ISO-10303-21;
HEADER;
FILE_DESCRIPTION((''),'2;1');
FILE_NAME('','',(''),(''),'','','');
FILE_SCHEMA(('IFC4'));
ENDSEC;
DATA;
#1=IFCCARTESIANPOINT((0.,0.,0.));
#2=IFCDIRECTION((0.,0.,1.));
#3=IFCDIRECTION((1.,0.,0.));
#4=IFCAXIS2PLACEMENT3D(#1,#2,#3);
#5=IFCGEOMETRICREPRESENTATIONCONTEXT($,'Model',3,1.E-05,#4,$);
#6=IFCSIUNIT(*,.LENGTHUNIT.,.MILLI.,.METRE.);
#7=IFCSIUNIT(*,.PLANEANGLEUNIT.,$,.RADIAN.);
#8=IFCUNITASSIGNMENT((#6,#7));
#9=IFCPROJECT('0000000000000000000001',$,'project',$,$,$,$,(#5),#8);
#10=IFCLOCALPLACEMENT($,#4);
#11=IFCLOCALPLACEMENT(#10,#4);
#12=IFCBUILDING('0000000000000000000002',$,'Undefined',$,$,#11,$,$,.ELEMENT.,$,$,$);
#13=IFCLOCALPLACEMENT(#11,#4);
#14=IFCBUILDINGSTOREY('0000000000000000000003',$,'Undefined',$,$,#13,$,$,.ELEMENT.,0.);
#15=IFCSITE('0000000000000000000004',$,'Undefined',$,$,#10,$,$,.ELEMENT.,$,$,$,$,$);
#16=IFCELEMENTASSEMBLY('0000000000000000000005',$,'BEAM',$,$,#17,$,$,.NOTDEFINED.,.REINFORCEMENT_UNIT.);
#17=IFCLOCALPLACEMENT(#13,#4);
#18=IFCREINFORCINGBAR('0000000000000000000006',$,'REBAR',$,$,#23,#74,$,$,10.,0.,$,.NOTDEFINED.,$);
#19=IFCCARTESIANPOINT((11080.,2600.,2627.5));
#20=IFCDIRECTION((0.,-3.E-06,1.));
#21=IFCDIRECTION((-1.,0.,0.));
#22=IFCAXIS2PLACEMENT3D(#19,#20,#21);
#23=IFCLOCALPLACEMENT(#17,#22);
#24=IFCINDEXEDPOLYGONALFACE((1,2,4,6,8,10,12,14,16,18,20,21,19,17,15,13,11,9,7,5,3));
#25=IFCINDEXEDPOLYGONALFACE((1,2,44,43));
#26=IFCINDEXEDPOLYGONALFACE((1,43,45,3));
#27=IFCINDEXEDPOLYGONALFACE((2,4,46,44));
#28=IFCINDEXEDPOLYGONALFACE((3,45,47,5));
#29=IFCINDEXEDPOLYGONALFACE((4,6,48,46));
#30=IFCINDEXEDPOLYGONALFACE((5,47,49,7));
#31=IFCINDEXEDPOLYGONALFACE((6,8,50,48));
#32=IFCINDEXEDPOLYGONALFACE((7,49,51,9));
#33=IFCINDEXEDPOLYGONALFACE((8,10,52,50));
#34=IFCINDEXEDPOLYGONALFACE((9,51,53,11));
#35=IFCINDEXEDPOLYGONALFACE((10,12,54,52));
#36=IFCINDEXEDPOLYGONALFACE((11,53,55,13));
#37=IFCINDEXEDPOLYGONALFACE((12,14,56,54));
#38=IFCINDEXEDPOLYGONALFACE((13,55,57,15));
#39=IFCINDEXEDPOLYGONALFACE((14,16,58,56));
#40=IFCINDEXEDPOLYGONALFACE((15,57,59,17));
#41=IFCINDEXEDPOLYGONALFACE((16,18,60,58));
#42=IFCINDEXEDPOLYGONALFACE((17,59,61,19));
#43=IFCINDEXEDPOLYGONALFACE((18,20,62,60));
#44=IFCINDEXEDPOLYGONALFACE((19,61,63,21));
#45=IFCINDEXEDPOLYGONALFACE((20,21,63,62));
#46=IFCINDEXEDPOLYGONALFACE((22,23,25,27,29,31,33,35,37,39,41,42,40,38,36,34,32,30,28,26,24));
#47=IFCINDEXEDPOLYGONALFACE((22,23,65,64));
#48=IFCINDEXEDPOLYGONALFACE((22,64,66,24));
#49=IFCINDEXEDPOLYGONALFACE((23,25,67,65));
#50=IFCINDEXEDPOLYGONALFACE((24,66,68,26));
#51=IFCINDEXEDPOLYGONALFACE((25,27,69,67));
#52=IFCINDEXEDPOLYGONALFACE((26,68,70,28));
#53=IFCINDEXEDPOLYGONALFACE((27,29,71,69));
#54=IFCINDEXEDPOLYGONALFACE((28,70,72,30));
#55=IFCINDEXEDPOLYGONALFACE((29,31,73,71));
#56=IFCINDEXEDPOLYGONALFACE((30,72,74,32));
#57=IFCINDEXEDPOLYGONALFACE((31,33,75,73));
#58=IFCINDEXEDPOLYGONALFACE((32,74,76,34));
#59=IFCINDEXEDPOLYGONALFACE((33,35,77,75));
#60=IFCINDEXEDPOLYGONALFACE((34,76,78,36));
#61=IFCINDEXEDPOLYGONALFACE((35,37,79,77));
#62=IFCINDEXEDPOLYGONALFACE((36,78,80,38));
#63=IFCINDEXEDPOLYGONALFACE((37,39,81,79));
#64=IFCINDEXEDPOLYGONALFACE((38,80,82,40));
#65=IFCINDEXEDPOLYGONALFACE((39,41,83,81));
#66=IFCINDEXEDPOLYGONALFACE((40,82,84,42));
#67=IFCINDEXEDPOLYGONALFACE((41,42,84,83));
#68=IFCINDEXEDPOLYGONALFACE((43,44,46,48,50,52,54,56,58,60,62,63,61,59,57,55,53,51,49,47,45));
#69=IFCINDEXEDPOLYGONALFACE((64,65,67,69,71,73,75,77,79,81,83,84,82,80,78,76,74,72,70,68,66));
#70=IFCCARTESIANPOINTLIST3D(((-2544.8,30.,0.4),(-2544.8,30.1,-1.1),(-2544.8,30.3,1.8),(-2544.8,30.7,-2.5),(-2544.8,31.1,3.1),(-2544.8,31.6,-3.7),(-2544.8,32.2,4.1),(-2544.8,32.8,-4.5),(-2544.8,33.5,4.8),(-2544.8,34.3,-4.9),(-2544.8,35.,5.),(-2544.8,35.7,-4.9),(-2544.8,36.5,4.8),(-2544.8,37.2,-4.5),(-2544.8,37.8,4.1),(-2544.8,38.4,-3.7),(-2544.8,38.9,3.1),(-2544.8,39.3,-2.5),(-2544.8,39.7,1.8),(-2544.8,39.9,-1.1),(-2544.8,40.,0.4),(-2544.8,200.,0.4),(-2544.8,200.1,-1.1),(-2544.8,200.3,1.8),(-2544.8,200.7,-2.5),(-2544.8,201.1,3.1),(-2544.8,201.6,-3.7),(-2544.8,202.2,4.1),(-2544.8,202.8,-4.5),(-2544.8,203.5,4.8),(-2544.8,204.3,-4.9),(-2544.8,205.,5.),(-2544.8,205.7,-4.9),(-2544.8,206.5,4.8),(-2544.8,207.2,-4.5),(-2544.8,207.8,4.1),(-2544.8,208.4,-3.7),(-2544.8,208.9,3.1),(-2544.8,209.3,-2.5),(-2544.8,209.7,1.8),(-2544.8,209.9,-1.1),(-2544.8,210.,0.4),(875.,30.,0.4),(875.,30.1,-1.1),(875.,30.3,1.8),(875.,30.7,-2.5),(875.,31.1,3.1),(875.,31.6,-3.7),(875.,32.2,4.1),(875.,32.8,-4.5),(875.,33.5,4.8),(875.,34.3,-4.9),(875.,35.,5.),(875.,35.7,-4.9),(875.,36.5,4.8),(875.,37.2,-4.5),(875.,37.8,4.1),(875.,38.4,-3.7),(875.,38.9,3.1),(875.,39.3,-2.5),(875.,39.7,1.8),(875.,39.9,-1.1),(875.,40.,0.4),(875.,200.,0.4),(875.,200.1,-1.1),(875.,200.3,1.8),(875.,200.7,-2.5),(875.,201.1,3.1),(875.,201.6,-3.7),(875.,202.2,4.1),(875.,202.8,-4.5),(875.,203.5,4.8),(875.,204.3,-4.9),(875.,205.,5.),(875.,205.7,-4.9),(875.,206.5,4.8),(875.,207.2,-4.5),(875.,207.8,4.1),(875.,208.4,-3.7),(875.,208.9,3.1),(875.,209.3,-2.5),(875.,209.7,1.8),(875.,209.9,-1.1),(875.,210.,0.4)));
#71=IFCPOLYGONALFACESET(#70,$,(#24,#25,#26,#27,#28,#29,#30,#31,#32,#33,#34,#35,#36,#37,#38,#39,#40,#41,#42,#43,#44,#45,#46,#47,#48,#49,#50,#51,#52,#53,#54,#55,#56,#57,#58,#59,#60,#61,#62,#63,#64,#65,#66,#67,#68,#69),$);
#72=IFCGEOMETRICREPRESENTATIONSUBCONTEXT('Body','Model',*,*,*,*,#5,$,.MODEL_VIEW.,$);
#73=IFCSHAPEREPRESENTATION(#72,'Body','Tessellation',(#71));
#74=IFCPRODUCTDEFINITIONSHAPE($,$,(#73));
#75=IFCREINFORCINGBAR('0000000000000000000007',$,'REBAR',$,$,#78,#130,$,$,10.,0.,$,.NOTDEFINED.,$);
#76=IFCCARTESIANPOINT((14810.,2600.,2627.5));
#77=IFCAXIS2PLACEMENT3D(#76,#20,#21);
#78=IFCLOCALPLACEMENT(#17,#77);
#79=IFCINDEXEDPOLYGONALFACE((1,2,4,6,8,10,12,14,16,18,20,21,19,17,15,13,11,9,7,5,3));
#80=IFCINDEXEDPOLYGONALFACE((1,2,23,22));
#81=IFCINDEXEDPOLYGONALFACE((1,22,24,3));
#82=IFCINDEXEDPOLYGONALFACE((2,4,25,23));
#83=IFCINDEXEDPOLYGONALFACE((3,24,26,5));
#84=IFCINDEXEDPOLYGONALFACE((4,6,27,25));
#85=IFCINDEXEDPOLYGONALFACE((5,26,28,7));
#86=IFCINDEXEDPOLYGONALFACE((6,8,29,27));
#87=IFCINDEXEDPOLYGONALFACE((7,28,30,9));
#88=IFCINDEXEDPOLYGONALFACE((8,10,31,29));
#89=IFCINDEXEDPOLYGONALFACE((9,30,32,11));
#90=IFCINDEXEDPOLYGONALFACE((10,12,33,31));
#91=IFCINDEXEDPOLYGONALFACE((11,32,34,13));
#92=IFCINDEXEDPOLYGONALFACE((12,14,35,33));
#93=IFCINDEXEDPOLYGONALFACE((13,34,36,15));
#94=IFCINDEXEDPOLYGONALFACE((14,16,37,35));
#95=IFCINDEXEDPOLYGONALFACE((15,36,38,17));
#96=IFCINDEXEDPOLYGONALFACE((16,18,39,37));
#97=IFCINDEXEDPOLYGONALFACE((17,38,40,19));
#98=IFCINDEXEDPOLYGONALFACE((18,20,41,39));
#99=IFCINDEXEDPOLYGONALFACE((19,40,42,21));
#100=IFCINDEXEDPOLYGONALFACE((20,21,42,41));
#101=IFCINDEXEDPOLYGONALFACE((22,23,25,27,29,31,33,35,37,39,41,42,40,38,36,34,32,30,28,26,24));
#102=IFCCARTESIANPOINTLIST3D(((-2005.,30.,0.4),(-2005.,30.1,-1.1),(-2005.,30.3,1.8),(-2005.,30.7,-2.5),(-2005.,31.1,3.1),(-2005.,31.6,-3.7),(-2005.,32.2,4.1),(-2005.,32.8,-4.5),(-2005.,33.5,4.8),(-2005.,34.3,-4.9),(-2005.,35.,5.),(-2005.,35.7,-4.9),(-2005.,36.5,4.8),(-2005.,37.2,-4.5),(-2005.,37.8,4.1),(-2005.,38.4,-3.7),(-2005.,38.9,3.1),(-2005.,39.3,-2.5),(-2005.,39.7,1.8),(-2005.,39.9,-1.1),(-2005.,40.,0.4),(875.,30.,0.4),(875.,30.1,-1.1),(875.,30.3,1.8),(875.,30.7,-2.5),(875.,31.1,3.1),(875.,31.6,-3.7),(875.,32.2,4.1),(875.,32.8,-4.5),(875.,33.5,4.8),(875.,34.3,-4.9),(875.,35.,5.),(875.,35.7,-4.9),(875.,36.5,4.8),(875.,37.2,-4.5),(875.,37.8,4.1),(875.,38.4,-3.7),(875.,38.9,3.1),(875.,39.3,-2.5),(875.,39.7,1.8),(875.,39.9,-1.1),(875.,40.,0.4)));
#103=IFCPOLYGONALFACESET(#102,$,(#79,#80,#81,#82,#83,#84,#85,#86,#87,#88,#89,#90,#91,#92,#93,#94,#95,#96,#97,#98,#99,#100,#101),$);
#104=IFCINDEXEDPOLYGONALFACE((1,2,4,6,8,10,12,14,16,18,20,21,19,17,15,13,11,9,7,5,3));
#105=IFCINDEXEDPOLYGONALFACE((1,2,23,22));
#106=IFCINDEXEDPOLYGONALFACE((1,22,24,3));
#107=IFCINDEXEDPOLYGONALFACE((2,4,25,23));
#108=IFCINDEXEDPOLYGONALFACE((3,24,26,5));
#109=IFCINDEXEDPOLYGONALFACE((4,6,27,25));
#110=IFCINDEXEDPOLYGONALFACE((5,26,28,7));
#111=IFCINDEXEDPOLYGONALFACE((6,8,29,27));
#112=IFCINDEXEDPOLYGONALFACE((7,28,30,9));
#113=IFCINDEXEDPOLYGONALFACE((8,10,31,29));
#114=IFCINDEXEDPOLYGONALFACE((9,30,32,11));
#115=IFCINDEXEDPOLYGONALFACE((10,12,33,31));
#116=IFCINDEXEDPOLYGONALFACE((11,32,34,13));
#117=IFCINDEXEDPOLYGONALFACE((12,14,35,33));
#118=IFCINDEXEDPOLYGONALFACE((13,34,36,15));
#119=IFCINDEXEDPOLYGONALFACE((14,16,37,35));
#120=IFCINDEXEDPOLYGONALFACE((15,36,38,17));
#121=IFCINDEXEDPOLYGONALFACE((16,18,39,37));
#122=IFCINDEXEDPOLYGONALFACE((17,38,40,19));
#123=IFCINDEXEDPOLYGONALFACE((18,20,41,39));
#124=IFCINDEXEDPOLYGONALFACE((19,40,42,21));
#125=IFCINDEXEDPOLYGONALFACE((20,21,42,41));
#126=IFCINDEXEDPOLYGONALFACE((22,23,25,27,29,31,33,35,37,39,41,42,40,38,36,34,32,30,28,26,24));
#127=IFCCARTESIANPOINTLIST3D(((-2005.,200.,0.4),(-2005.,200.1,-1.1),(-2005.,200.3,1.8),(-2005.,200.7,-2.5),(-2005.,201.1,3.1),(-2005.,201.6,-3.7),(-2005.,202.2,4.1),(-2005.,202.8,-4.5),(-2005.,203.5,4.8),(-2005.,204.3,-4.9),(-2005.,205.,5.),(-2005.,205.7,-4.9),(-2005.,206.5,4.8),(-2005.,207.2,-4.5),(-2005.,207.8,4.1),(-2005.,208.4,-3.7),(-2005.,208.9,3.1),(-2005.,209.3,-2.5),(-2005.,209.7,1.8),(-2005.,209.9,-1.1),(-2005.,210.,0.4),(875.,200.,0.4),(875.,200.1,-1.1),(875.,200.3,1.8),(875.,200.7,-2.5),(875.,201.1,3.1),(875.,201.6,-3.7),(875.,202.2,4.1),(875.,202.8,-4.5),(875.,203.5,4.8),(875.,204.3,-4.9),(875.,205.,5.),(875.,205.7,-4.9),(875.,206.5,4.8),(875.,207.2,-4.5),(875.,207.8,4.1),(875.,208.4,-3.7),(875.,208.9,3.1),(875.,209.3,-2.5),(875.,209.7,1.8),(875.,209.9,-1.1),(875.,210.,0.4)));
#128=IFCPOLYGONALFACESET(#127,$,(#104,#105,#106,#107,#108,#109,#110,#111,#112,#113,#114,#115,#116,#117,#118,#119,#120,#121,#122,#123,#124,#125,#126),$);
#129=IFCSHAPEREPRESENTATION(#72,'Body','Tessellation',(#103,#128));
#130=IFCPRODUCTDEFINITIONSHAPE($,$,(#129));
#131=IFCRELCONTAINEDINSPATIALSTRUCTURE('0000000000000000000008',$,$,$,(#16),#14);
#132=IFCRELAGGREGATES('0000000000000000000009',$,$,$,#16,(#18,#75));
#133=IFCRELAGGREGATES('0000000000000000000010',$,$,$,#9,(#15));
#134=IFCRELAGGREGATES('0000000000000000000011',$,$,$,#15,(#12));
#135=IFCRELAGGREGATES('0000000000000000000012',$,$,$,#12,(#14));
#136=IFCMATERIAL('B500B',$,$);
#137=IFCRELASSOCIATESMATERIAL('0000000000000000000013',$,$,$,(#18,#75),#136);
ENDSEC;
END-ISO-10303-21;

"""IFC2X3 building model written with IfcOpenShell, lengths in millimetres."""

from ifc_helpers import new_model, entity, si_unit, frame, origin_with_axes, place, context, subcontext, project, spatial, source, transform, mapped, material, element, aggregate, save


model = new_model("IFC2X3")

# Units and contexts
model_context = context("Model", 3, precision=1e-05, world=origin_with_axes())
body_context = subcontext(model_context, "Body", "Model", "MODEL_VIEW")
ifc_project = project(units=[si_unit("LENGTHUNIT", "METRE", prefix="MILLI"), si_unit("PLANEANGLEUNIT", "RADIAN")], contexts=[model_context])

# Site, building, storey
site_placement = place(None, origin_with_axes())
site = spatial("IfcSite", under=ifc_project, at=site_placement, Name="Undefined", CompositionType="ELEMENT")
building_placement = place(site_placement, origin_with_axes())
building = spatial("IfcBuilding", under=site, at=building_placement, Name="Undefined", CompositionType="ELEMENT")
storey_placement = place(building_placement, origin_with_axes())
storey = spatial("IfcBuildingStorey", under=building, at=storey_placement, Name="Undefined", CompositionType="ELEMENT", Elevation=0.0)

# Element assembly
assembly_1_placement = place(storey_placement, origin_with_axes())
assembly_1 = element("IfcElementAssembly", 1, at=assembly_1_placement, inside=storey, Name="BEAM", AssemblyPlace="NOTDEFINED", PredefinedType="REINFORCEMENT_UNIT")

# Reinforcing bars
ifc_material_1 = material(Name="B500B")
shared_shape_1 = source(origin_with_axes(), body_context, "Body", "AdvancedSweptSolid", [
    entity("IfcSweptDiskSolid", entity("IfcTrimmedCurve", entity("IfcLine", entity("IfcCartesianPoint", [0.0, 0.0, 0.0]), entity("IfcVector", entity("IfcDirection", [1.0, 0.0, 0.0]), 1.0)), [entity("IfcParameterValue", 0.0)], [entity("IfcParameterValue", 3419.772834)], True, "PARAMETER"), 5.0, None, 0.0, 3419.8),
])
shared_shape_2 = source(origin_with_axes(), body_context, "Body", "AdvancedSweptSolid", [
    entity("IfcSweptDiskSolid", entity("IfcTrimmedCurve", entity("IfcLine", entity("IfcCartesianPoint", [0.0, 0.0, 0.0]), entity("IfcVector", entity("IfcDirection", [1.0, 0.0, 0.0]), 1.0)), [entity("IfcParameterValue", 0.0)], [entity("IfcParameterValue", 3419.772834)], True, "PARAMETER"), 5.0, None, 0.0, 3419.8),
])
reinforcing_bar_1_placement = place(assembly_1_placement, frame((11080.0, 2600.0, 2627.5), z_axis=(0.0, -0.000003, 1.0), x_axis=(-1.0, 0.0, 0.0)))
reinforcing_bar_1 = element("IfcReinforcingBar", 2, at=reinforcing_bar_1_placement, material=ifc_material_1, Name="REBAR", BarRole="NOTDEFINED", CrossSectionArea=0.0, NominalDiameter=10.0, context=body_context, shape_type="MappedRepresentation", body=[
    mapped(shared_shape_1, transform((-2544.8, 35.0, 0.0))),
    mapped(shared_shape_2, transform((-2544.8, 205.0, 0.0))),
])
shared_shape_3 = source(origin_with_axes(), body_context, "Body", "AdvancedSweptSolid", [
    entity("IfcSweptDiskSolid", entity("IfcTrimmedCurve", entity("IfcLine", entity("IfcCartesianPoint", [0.0, 0.0, 0.0]), entity("IfcVector", entity("IfcDirection", [1.0, 0.0, 0.0]), 1.0)), [entity("IfcParameterValue", 0.0)], [entity("IfcParameterValue", 2880.002834)], True, "PARAMETER"), 5.0, None, 0.0, 2880.0),
])
shared_shape_4 = source(origin_with_axes(), body_context, "Body", "AdvancedSweptSolid", [
    entity("IfcSweptDiskSolid", entity("IfcTrimmedCurve", entity("IfcLine", entity("IfcCartesianPoint", [0.0, 0.0, 0.0]), entity("IfcVector", entity("IfcDirection", [1.0, 0.0, 0.0]), 1.0)), [entity("IfcParameterValue", 0.0)], [entity("IfcParameterValue", 2880.002834)], True, "PARAMETER"), 5.0, None, 0.0, 2880.0),
])
reinforcing_bar_2_placement = place(assembly_1_placement, frame((14810.0, 2600.0, 2627.5), z_axis=(0.0, -0.000003, 1.0), x_axis=(-1.0, 0.0, 0.0)))
reinforcing_bar_2 = element("IfcReinforcingBar", 3, at=reinforcing_bar_2_placement, material=ifc_material_1, Name="REBAR", BarRole="NOTDEFINED", CrossSectionArea=0.0, NominalDiameter=10.0, context=body_context, shape_type="MappedRepresentation", body=[
    mapped(shared_shape_3, transform((-2005.0, 35.0, 0.0))),
    mapped(shared_shape_4, transform((-2005.0, 205.0, 0.0))),
])
aggregate(assembly_1, [reinforcing_bar_1, reinforcing_bar_2])

save(model, "model.ifc")
